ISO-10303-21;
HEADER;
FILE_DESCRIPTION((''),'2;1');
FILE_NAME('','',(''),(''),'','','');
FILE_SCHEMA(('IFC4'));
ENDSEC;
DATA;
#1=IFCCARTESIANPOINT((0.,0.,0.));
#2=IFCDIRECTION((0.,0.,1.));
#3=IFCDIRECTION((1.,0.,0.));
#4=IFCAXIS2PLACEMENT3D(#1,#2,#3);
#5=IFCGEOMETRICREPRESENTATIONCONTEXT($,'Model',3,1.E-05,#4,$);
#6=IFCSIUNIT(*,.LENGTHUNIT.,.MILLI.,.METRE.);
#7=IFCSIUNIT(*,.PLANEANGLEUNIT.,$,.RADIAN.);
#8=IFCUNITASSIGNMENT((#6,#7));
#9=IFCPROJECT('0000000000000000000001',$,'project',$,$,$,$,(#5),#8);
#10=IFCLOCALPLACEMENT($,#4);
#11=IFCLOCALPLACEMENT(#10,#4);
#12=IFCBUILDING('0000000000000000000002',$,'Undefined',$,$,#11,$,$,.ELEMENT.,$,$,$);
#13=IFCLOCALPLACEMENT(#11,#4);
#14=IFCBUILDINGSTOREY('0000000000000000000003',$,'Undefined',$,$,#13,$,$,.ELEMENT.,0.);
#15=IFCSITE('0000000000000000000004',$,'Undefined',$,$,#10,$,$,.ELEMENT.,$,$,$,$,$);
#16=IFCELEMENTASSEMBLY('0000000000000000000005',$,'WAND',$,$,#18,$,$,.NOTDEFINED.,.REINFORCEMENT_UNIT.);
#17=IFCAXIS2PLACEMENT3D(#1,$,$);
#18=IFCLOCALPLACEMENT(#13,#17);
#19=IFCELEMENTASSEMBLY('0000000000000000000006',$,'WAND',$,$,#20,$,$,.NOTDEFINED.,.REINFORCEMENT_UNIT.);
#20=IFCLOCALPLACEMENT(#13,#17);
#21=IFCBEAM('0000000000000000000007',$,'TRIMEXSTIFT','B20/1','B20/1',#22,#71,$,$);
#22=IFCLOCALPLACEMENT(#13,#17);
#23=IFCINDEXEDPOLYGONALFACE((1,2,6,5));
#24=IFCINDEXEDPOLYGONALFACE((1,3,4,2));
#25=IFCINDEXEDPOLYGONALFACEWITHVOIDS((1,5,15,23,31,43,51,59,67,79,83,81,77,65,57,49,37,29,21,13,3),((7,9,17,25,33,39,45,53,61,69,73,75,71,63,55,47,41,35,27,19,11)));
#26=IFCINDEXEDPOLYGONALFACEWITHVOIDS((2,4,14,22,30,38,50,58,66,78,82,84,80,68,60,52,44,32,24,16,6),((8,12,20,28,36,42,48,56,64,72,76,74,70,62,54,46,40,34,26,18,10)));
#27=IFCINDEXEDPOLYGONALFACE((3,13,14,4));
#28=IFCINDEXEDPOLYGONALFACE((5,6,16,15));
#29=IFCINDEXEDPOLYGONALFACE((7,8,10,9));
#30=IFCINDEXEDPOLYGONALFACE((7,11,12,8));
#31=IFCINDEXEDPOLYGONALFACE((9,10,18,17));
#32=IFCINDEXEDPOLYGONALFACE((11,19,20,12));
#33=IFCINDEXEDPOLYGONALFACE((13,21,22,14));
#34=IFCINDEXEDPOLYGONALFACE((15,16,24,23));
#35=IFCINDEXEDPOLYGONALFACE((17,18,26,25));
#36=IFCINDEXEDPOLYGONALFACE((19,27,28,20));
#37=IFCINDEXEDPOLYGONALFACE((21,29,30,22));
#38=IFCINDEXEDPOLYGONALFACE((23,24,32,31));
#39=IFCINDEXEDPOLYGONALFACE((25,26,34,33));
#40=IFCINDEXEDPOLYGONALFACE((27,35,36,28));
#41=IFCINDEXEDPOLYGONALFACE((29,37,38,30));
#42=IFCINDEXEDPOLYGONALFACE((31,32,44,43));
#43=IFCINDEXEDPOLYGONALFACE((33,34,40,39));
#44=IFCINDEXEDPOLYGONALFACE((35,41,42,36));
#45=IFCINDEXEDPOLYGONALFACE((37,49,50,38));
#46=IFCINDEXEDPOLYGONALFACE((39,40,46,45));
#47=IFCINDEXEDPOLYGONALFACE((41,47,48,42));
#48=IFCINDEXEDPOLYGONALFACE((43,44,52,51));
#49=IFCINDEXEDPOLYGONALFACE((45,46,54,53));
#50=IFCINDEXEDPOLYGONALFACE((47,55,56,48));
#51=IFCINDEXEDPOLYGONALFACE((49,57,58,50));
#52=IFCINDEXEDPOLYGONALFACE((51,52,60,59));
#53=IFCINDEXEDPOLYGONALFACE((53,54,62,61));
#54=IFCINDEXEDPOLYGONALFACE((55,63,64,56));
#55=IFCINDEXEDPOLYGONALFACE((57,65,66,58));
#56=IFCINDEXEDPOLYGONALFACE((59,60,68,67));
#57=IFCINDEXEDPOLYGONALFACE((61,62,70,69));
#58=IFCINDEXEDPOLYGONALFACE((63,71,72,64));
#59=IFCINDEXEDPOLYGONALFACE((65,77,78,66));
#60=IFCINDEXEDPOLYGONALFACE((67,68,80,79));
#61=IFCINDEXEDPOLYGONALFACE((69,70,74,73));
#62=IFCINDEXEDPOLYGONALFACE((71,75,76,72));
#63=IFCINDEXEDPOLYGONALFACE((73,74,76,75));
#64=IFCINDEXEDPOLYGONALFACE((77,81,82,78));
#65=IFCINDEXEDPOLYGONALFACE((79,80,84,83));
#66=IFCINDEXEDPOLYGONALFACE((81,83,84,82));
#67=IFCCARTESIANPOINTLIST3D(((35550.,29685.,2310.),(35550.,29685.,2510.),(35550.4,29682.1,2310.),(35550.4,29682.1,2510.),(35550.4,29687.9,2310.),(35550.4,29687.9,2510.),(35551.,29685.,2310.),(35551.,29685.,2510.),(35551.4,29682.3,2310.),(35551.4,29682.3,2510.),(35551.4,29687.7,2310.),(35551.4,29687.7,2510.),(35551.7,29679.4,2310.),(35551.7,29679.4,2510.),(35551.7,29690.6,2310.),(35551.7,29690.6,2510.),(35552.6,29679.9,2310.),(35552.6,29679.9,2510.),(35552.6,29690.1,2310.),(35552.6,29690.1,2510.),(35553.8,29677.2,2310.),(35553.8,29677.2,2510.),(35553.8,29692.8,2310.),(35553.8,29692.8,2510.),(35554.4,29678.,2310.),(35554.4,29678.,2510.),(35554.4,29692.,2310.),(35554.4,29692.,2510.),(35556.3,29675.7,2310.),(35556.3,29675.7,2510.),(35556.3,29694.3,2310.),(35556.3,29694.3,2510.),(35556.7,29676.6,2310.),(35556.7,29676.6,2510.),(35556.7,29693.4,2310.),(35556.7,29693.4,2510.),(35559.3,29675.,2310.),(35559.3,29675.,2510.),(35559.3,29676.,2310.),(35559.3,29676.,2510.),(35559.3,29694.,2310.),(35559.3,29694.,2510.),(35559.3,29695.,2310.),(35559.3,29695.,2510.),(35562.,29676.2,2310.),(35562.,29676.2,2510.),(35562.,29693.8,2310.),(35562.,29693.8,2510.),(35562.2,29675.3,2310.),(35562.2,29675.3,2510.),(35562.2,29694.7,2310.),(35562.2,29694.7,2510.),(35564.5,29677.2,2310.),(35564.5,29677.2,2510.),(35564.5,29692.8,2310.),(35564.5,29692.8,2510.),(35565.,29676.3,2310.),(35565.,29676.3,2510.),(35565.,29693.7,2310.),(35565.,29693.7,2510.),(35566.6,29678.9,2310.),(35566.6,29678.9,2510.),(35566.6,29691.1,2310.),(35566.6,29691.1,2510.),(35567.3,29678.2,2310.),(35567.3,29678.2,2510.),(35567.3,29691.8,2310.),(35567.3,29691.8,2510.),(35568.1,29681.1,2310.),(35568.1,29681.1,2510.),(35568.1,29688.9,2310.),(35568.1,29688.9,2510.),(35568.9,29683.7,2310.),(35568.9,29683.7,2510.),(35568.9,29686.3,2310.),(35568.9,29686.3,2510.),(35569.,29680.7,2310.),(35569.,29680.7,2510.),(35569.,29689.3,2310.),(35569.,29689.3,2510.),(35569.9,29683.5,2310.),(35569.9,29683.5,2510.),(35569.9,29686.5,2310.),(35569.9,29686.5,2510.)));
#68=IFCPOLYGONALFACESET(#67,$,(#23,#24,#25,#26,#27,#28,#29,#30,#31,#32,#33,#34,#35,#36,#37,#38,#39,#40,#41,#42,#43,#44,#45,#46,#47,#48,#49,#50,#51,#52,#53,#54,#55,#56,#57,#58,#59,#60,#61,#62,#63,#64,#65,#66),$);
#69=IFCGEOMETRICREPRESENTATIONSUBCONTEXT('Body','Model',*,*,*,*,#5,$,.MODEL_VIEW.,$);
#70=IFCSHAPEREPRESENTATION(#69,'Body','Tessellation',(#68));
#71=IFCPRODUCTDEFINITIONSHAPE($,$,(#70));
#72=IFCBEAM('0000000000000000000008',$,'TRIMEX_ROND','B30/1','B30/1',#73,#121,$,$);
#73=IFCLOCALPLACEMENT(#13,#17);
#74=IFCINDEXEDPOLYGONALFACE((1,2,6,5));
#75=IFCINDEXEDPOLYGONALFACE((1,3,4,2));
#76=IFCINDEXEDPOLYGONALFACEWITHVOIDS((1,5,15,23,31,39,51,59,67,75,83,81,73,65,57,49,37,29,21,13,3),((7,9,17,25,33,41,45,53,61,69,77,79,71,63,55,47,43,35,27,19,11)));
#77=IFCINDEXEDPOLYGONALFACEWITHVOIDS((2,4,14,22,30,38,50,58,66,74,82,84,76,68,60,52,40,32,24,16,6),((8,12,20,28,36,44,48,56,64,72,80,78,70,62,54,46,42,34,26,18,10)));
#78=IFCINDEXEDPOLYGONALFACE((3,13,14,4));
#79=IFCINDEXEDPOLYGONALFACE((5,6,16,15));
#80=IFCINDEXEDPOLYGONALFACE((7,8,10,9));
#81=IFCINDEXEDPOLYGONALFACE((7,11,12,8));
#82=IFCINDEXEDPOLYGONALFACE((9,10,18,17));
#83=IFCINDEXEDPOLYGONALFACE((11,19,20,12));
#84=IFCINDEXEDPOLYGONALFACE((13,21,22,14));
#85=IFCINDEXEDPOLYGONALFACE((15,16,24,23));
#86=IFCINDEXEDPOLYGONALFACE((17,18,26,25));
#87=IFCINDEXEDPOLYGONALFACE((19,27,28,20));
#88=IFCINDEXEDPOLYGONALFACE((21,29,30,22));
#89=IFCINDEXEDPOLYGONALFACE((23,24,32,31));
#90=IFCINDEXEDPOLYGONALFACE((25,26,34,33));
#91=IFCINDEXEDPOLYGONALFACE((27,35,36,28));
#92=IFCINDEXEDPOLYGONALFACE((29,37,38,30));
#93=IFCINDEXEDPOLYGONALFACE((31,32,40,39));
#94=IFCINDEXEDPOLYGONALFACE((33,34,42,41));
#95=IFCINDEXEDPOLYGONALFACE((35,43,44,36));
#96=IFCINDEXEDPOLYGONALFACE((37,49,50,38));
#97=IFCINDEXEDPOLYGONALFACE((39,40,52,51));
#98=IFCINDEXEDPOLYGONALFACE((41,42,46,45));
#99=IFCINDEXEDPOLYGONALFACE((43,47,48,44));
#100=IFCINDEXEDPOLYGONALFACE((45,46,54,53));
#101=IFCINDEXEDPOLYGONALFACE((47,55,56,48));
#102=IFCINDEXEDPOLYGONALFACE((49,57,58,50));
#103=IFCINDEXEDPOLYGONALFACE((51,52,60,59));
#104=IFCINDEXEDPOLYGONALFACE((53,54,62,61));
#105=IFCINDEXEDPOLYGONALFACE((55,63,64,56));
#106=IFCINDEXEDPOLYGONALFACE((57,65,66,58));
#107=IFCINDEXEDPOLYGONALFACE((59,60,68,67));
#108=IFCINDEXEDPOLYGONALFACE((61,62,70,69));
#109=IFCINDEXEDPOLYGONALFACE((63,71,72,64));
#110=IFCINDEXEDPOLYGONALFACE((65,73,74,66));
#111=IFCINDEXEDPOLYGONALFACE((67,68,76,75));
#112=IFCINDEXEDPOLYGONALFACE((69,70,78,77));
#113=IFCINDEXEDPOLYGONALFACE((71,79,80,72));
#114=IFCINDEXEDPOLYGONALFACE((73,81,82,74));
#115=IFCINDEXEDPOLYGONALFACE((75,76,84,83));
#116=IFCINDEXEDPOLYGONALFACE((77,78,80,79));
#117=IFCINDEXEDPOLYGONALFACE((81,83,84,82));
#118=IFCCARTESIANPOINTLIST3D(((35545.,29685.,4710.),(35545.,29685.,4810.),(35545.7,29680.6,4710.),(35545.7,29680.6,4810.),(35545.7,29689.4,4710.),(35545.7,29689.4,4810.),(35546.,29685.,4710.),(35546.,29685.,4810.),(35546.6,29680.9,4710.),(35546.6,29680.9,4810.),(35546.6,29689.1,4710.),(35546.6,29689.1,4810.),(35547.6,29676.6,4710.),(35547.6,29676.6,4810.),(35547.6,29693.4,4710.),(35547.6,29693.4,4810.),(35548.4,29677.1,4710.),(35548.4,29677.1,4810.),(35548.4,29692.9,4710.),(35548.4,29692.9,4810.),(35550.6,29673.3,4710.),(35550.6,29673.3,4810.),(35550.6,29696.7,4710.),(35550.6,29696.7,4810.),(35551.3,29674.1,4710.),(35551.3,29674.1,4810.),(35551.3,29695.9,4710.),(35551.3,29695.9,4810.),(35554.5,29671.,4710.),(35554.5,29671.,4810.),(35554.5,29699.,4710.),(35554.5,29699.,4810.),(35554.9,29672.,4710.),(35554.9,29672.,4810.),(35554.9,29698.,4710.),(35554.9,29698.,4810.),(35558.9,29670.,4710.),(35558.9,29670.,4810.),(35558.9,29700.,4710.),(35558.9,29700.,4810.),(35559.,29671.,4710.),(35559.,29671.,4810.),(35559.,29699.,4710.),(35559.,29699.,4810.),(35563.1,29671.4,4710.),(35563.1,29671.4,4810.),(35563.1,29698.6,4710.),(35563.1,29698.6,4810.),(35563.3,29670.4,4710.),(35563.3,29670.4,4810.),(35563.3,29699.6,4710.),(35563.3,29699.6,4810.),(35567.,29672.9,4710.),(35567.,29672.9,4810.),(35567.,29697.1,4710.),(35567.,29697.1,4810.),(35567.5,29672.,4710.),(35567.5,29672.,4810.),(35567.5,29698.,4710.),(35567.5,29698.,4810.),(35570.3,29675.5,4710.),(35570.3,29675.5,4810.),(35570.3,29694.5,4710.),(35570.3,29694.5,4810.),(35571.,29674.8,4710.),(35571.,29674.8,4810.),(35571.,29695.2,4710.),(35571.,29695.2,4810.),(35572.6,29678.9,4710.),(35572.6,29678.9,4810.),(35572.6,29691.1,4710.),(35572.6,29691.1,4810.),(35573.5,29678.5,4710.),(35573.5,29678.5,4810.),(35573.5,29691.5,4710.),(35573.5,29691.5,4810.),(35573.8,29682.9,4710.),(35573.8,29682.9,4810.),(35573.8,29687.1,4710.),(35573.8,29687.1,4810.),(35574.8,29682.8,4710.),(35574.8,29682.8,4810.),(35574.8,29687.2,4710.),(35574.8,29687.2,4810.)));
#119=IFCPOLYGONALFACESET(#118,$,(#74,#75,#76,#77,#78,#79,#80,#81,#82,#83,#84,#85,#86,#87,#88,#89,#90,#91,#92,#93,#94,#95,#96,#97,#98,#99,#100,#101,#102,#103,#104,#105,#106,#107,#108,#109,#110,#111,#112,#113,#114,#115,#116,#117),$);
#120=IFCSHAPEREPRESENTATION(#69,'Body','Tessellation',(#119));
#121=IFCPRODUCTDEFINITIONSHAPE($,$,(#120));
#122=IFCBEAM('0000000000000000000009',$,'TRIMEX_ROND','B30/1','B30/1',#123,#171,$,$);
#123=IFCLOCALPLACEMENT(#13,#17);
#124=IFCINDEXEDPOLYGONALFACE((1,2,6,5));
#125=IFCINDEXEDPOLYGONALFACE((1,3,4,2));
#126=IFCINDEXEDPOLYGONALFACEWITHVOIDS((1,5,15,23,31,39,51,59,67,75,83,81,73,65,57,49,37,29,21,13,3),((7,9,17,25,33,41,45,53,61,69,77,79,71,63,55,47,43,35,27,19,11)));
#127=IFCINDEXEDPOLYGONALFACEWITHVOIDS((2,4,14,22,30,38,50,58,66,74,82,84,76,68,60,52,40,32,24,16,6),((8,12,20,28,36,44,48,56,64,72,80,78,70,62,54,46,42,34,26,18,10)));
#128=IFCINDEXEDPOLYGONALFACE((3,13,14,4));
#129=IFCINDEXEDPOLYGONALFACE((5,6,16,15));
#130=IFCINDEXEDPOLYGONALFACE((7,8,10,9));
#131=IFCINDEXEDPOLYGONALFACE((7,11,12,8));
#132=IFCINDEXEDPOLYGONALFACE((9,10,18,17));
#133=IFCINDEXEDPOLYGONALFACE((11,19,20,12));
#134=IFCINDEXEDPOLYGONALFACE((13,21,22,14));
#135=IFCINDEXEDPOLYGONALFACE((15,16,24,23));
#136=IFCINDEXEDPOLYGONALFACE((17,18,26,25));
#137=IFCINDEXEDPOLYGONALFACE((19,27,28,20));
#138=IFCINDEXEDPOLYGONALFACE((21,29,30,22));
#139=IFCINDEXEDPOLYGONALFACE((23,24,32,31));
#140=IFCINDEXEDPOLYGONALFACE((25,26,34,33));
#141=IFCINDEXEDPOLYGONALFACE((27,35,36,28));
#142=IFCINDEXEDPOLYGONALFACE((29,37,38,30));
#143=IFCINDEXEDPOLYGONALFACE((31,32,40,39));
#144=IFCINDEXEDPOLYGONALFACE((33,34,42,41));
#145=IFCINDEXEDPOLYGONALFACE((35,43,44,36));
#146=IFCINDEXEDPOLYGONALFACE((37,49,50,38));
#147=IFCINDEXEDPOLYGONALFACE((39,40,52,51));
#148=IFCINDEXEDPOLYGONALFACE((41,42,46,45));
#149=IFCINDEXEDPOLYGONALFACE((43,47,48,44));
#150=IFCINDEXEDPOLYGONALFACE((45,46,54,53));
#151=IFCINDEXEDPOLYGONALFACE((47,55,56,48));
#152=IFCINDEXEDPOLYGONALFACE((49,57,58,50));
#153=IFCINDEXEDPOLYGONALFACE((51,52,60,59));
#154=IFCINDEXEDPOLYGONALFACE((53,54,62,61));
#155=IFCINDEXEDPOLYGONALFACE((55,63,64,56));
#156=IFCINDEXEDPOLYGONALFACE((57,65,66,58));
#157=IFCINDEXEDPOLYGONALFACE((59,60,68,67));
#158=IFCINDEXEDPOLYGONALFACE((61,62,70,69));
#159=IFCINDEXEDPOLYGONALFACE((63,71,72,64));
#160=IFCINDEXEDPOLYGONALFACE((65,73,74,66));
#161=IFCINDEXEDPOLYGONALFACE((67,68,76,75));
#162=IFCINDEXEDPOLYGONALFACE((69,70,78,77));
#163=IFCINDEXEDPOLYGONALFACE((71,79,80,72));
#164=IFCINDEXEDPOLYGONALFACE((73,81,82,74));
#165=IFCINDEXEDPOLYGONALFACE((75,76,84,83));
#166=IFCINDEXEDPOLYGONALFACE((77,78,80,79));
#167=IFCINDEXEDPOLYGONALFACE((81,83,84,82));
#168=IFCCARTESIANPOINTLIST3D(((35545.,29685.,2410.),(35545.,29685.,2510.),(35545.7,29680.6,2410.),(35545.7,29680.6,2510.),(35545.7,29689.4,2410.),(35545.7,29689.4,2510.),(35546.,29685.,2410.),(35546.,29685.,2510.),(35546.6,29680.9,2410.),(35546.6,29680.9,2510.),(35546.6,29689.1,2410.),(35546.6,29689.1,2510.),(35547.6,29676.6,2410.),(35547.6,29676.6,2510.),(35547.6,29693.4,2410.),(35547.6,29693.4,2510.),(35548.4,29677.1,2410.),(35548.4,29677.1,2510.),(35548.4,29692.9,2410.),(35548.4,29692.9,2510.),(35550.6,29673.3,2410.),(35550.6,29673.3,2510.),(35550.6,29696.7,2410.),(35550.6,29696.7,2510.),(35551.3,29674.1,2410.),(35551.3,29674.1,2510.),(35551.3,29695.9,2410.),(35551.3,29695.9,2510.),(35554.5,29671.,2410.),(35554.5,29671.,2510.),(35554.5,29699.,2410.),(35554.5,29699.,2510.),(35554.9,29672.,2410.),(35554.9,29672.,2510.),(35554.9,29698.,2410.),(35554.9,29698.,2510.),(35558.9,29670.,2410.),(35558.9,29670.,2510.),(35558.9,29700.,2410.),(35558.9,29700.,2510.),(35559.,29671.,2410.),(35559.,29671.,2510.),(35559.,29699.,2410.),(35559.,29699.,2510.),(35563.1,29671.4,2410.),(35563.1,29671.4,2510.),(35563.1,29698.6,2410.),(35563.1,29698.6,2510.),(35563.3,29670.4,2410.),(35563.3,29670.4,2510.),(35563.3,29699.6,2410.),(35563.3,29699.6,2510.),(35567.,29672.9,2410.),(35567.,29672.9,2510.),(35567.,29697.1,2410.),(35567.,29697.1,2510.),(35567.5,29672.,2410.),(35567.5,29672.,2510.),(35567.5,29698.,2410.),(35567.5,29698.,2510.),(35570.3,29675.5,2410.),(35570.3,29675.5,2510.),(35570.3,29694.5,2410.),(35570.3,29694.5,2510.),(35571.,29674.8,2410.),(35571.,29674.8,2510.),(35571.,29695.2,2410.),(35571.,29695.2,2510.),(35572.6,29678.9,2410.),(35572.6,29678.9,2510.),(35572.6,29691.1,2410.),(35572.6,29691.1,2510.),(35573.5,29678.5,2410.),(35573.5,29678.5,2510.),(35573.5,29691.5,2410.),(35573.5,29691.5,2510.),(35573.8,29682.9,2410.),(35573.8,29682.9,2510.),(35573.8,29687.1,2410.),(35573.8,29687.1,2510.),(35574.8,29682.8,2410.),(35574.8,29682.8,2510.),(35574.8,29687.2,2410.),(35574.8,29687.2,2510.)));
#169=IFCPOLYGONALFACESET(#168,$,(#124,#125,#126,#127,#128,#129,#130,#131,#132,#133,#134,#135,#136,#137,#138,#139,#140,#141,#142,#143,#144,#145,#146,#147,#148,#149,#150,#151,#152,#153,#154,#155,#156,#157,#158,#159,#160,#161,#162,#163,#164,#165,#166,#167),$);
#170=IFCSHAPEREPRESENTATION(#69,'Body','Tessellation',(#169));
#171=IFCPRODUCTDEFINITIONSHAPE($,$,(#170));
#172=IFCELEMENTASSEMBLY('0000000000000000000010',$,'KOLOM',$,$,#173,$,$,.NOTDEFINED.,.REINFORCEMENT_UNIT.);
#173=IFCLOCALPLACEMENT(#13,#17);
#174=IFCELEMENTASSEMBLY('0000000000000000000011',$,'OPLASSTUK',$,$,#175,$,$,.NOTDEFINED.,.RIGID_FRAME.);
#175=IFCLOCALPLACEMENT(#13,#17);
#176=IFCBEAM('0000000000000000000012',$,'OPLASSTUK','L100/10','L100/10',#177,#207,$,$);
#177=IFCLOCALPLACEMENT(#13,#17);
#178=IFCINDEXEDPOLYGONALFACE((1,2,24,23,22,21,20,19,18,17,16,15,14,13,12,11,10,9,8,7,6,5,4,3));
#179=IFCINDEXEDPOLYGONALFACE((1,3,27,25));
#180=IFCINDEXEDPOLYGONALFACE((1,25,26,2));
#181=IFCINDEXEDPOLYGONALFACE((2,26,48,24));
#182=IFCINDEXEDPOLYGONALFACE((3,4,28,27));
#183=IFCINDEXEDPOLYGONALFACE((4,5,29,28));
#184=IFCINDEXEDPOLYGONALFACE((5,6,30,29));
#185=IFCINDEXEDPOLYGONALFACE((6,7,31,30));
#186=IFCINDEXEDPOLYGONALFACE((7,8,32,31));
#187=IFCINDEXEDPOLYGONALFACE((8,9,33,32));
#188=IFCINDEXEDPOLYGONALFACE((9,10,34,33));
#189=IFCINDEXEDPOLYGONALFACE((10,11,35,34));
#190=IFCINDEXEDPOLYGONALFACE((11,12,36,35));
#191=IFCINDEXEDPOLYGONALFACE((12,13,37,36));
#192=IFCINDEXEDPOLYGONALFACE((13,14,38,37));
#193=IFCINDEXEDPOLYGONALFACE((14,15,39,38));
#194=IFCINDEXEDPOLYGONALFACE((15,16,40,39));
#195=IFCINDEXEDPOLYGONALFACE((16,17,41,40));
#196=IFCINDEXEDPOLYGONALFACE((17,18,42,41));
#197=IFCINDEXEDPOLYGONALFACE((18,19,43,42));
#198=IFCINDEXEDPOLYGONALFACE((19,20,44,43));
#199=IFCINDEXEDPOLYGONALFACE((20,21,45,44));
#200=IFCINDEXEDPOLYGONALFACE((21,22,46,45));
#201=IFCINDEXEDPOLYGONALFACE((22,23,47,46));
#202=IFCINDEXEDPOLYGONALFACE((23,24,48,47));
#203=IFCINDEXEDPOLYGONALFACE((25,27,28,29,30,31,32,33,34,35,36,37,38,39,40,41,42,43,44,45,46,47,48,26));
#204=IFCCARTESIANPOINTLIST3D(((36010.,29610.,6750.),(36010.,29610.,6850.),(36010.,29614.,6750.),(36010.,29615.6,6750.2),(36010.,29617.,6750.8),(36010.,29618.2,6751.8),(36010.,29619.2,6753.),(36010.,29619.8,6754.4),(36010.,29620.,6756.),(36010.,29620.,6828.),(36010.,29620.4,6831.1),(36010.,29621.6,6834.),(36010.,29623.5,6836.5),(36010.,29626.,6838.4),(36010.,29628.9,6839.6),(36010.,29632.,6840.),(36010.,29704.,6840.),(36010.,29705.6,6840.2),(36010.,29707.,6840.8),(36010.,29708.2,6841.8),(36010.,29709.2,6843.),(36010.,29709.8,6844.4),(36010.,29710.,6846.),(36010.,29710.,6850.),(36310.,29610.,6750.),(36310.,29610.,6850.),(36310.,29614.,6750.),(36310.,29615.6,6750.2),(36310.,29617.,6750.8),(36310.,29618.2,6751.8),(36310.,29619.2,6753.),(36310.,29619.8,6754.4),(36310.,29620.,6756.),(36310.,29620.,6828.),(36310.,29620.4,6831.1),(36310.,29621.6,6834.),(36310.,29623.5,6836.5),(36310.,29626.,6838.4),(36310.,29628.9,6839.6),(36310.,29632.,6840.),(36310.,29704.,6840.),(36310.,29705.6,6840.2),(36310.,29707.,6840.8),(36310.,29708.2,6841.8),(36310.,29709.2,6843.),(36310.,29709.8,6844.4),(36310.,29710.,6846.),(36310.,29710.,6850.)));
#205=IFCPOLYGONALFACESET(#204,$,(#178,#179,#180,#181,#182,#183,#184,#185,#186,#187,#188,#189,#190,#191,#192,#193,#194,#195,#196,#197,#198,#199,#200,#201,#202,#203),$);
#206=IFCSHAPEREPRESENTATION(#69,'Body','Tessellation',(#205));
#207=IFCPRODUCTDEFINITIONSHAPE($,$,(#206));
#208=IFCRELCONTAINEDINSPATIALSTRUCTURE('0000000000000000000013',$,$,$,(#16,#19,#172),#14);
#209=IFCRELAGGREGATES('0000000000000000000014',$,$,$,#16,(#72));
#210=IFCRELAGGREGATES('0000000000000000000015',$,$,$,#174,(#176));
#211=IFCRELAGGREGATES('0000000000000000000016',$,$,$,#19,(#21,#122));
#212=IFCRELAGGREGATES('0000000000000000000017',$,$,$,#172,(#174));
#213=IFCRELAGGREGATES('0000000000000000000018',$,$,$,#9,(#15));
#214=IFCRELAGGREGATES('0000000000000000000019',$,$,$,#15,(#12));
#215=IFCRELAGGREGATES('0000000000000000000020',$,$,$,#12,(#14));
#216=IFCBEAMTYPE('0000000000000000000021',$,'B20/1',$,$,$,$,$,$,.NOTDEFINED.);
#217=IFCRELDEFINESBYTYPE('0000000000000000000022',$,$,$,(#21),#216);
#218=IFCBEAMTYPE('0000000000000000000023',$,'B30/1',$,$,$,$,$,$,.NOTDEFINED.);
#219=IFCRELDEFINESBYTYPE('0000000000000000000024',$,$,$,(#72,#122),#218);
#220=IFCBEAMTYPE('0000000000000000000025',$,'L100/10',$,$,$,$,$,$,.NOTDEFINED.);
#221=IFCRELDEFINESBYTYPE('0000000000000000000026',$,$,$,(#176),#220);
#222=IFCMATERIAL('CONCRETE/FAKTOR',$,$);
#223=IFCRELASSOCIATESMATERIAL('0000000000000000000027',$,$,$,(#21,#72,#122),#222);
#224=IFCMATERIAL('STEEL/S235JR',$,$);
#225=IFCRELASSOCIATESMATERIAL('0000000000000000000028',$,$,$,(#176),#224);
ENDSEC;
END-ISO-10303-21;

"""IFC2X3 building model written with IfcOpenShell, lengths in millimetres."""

from ifc_helpers import new_model, si_unit, frame, frame_2d, origin_with_axes, place, context, subcontext, project, spatial, hollow_circle, l_section, extrude, material, type_object, element, aggregate, save


model = new_model("IFC2X3")

# Units and contexts
model_context = context("Model", 3, precision=1e-05, world=origin_with_axes())
body_context = subcontext(model_context, "Body", "Model", "MODEL_VIEW")
ifc_project = project(units=[si_unit("LENGTHUNIT", "METRE", prefix="MILLI"), si_unit("PLANEANGLEUNIT", "RADIAN")], contexts=[model_context])

# Site, building, storey
site_placement = place(None, origin_with_axes())
site = spatial("IfcSite", under=ifc_project, at=site_placement, Name="Undefined", CompositionType="ELEMENT")
building_placement = place(site_placement, origin_with_axes())
building = spatial("IfcBuilding", under=site, at=building_placement, Name="Undefined", CompositionType="ELEMENT")
storey_placement = place(building_placement, origin_with_axes())
storey = spatial("IfcBuildingStorey", under=building, at=storey_placement, Name="Undefined", CompositionType="ELEMENT", Elevation=0.0)

# Shared definitions
ifc_material_1 = material(Name="STEEL/S235JR")

# Element assembly
assembly_1_placement = place(storey_placement, origin_with_axes())
assembly_1 = element("IfcElementAssembly", 1, at=assembly_1_placement, inside=storey, Name="WAND", AssemblyPlace="NOTDEFINED", PredefinedType="REINFORCEMENT_UNIT")

# Element assembly
assembly_2_placement = place(storey_placement, origin_with_axes())
assembly_2 = element("IfcElementAssembly", 2, at=assembly_2_placement, inside=storey, Name="WAND", AssemblyPlace="NOTDEFINED", PredefinedType="REINFORCEMENT_UNIT")
ifc_material_2 = material(Name="CONCRETE/FAKTOR")
beam_type_1 = type_object("IfcBeamType", Name="B20/1", PredefinedType="NOTDEFINED")

# Beams
beam_1_placement = place(assembly_2_placement, frame((35560.0, 29685.0, 2310.0), z_axis=(0.0, 1.0, 0.0), x_axis=(0.0, 0.0, 1.0)))
beam_1 = element("IfcBeam", 3, at=beam_1_placement, type_object=beam_type_1, material=ifc_material_2, Name="TRIMEXSTIFT", Description="B20/1", ObjectType="B20/1", context=body_context, shape_type="SweptSolid", body=[
    extrude(hollow_circle(Radius=10.0, WallThickness=1.0, at=frame_2d((0.0, 0.0), x_axis=(1.0, 0.0))), frame((200.0, 0.0, 0.0), z_axis=(-1.0, 0.0, 0.0), x_axis=(0.0, -1.0, 0.0)), (0.0, 0.0, 1.0), 200.0),
])
beam_type_2 = type_object("IfcBeamType", Name="B30/1", PredefinedType="NOTDEFINED")
beam_2_placement = place(assembly_1_placement, frame((35560.0, 29685.0, 4710.0), z_axis=(0.0, 1.0, 0.0), x_axis=(0.0, 0.0, 1.0)))
beam_2 = element("IfcBeam", 4, at=beam_2_placement, type_object=beam_type_2, material=ifc_material_2, Name="TRIMEX_ROND", Description="B30/1", ObjectType="B30/1", context=body_context, shape_type="SweptSolid", body=[
    extrude(hollow_circle(Radius=15.0, WallThickness=1.0, at=frame_2d((0.0, 0.0), x_axis=(1.0, 0.0))), frame((100.0, 0.0, 0.0), z_axis=(-1.0, 0.0, 0.0), x_axis=(0.0, -1.0, 0.0)), (0.0, 0.0, 1.0), 100.0),
])
aggregate(assembly_1, [beam_2])
beam_3_placement = place(assembly_2_placement, frame((35560.0, 29685.0, 2410.0), z_axis=(0.0, 1.0, 0.0), x_axis=(0.0, 0.0, 1.0)))
beam_3 = element("IfcBeam", 5, at=beam_3_placement, type_object=beam_type_2, material=ifc_material_2, Name="TRIMEX_ROND", Description="B30/1", ObjectType="B30/1", context=body_context, shape_type="SweptSolid", body=[
    extrude(hollow_circle(Radius=15.0, WallThickness=1.0, at=frame_2d((0.0, 0.0), x_axis=(1.0, 0.0))), frame((100.0, 0.0, 0.0), z_axis=(-1.0, 0.0, 0.0), x_axis=(0.0, -1.0, 0.0)), (0.0, 0.0, 1.0), 100.0),
])

# Element assemblies, beam
assembly_3_placement = place(storey_placement, origin_with_axes())
assembly_3 = element("IfcElementAssembly", 6, at=assembly_3_placement, inside=storey, Name="KOLOM", AssemblyPlace="NOTDEFINED", PredefinedType="REINFORCEMENT_UNIT")
assembly_4_placement = place(assembly_3_placement, origin_with_axes())
assembly_4 = element("IfcElementAssembly", 7, at=assembly_4_placement, Name="OPLASSTUK", AssemblyPlace="NOTDEFINED", PredefinedType="RIGID_FRAME")
beam_type_3 = type_object("IfcBeamType", Name="L100/10", PredefinedType="NOTDEFINED")
beam_4_placement = place(assembly_4_placement, frame((36010.0, 29660.0, 6800.0), z_axis=(0.0, 0.0, -1.0), x_axis=(1.0, 0.0, 0.0)))
beam_4 = element("IfcBeam", 8, at=beam_4_placement, type_object=beam_type_3, material=ifc_material_1, Name="OPLASSTUK", Description="L100/10", ObjectType="L100/10", context=body_context, shape_type="SweptSolid", body=[
    extrude(l_section(Depth=100.0, Width=100.0, Thickness=10.0, FilletRadius=12.0, EdgeRadius=6.0, at=frame_2d((0.0, 0.0), x_axis=(1.0, 0.0))), frame((300.0, 0.0, 0.0), z_axis=(-1.0, 0.0, 0.0), x_axis=(0.0, -1.0, 0.0)), (0.0, 0.0, 1.0), 300.0),
])
aggregate(assembly_4, [beam_4])

aggregate(assembly_2, [beam_1, beam_3])

aggregate(assembly_3, [assembly_4])

save(model, "model.ifc")
